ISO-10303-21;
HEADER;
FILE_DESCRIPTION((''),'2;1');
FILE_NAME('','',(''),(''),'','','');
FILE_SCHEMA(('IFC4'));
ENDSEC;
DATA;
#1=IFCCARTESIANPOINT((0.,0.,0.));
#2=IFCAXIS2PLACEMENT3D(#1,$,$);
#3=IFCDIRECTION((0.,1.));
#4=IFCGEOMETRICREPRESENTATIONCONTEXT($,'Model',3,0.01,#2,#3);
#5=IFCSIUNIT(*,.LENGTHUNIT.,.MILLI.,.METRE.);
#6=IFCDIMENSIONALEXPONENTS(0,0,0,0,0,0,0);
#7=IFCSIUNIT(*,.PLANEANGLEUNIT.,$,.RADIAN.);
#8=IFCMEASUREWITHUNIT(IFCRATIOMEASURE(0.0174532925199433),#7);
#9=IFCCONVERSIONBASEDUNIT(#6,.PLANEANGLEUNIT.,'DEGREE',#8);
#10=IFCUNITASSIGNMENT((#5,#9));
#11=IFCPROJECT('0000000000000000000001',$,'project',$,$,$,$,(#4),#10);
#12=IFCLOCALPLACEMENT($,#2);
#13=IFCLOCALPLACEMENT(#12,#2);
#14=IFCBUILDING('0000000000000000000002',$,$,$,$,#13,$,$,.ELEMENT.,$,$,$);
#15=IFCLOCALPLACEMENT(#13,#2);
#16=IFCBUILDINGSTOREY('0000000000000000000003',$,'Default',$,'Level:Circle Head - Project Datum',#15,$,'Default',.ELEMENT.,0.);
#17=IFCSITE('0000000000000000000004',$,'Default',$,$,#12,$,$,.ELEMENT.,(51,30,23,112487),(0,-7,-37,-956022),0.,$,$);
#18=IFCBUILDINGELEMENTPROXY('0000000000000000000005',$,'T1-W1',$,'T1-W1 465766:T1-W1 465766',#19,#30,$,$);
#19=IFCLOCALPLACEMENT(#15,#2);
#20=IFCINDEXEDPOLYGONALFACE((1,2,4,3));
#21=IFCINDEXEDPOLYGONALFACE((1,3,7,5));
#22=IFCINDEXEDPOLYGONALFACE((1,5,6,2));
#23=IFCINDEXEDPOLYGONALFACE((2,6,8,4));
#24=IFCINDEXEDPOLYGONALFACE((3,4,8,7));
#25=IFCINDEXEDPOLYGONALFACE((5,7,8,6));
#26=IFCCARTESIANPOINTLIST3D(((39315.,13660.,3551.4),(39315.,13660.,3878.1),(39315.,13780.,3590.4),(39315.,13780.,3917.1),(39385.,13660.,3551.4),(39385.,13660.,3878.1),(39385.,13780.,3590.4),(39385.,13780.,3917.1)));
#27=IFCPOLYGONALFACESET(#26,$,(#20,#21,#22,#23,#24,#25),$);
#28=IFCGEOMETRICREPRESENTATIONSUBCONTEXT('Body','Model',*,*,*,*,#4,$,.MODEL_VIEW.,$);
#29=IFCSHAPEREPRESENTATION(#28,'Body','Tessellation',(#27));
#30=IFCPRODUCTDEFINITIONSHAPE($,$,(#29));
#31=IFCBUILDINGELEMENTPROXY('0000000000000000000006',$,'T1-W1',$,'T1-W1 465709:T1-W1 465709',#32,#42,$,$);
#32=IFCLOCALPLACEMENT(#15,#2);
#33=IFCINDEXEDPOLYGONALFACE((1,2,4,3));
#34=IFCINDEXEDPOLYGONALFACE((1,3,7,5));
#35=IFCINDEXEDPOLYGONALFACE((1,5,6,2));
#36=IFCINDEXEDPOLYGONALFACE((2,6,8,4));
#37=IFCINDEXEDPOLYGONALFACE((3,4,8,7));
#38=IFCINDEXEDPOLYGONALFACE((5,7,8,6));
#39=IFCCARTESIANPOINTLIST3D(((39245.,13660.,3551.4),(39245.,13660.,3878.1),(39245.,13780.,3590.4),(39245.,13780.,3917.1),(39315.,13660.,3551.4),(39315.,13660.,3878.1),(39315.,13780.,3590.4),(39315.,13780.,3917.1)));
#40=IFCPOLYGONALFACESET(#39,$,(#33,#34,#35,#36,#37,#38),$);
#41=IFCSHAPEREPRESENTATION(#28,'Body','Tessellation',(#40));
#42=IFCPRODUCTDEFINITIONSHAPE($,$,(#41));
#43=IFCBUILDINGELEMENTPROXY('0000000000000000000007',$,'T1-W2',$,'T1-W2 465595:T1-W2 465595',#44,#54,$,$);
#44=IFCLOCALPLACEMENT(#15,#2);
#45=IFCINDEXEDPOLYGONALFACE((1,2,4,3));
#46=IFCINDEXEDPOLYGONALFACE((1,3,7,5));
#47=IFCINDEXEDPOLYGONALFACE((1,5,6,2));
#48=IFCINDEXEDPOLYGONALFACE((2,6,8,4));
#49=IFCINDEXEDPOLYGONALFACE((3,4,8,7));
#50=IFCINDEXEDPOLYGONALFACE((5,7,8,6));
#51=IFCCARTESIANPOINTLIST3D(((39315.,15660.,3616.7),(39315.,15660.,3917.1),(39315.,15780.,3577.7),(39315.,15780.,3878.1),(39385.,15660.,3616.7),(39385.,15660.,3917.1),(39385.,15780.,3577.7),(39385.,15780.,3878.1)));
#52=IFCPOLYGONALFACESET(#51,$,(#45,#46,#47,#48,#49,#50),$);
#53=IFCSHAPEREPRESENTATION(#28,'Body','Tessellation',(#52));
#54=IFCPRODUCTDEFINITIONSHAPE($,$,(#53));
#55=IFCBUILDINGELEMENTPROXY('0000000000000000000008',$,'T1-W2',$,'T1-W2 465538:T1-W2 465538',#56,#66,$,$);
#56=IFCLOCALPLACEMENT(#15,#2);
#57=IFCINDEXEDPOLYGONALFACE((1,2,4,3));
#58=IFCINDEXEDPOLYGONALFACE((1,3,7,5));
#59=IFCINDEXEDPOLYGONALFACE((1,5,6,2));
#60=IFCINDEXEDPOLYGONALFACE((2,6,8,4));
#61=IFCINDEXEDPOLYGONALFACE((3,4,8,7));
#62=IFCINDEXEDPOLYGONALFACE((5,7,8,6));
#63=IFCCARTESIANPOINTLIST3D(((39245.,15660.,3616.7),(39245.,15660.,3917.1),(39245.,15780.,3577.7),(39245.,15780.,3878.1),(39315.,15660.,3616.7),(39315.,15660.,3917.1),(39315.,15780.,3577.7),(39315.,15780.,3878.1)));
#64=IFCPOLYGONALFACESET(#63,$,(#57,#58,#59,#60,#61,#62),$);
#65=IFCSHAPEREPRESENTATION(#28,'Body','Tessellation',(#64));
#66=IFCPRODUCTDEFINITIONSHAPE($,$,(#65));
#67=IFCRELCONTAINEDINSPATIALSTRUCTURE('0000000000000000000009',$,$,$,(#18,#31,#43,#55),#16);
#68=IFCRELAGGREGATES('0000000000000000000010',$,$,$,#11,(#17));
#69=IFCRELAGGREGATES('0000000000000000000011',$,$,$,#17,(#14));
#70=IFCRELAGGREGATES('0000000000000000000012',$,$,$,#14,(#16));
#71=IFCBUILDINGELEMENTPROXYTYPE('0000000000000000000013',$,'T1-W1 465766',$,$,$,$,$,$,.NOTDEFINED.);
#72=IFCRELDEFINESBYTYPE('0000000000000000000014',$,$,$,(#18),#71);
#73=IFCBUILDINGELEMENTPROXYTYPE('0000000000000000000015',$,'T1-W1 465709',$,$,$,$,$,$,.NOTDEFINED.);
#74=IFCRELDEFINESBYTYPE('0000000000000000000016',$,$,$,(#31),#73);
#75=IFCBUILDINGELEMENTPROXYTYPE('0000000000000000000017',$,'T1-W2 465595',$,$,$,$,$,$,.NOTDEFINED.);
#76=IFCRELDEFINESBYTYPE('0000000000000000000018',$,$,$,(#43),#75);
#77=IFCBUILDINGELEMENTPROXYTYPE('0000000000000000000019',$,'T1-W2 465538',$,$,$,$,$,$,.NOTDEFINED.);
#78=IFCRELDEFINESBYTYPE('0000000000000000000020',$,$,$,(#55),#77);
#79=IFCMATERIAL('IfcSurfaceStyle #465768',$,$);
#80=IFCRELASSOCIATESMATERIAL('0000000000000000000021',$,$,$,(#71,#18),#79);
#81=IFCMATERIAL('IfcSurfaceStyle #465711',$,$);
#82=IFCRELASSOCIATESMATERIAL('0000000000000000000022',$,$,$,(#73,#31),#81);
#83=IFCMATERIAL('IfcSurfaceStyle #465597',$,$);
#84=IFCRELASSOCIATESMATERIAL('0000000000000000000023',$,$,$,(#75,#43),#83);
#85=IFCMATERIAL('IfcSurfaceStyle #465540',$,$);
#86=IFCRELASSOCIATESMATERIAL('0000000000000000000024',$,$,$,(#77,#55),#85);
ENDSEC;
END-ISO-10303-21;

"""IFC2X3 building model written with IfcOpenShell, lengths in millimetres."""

from ifc_helpers import new_model, entity, si_unit, converted_unit, direction, frame, origin, place, context, subcontext, project, spatial, polyline, outline, extrude, source, transform, mapped, material, type_object, type_shapes, element, save


model = new_model("IFC2X3")

# Units and contexts
model_context = context("Model", 3, precision=0.01, world=origin(), true_north=direction((0.0, 1.0)))
body_context = subcontext(model_context, "Body", "Model", "MODEL_VIEW")
ifc_project = project(units=[si_unit("LENGTHUNIT", "METRE", prefix="MILLI"), converted_unit("PLANEANGLEUNIT", "DEGREE", entity("IfcRatioMeasure", 0.0174532925199433), si_unit("PLANEANGLEUNIT", "RADIAN"), dimensions=[0, 0, 0, 0, 0, 0, 0])], contexts=[model_context])

# Site, building, storey
site_placement = place(None, origin())
site = spatial("IfcSite", under=ifc_project, at=site_placement, Name="Default", CompositionType="ELEMENT", RefLatitude=(51, 30, 23, 112487), RefLongitude=(0, -7, -37, -956022), RefElevation=0.0)
building_placement = place(site_placement, origin())
building = spatial("IfcBuilding", under=site, at=building_placement, CompositionType="ELEMENT")
storey_placement = place(building_placement, origin())
storey = spatial("IfcBuildingStorey", under=building, at=storey_placement, Name="Default", ObjectType="Level:Circle Head - Project Datum", LongName="Default", CompositionType="ELEMENT", Elevation=0.0)

# Building element proxies
ifc_material_1 = material(Name="IfcSurfaceStyle #465768")
building_element_proxy_type_1 = type_object("IfcBuildingElementProxyType", Name="T1-W1 465766", PredefinedType="NOTDEFINED", material=ifc_material_1)
shared_shape_1 = source(origin(), body_context, "Body", "SweptSolid", [
    extrude(outline(polyline([(-182.8, -60.0), (143.8, -60.0), (182.8, 60.0), (-143.8, 60.0), (-182.8, -60.0)])), frame((182.8, 60.0, 0.0), z_axis=(0.0, 0.0, 1.0), x_axis=(-1.0, 0.0, 0.0)), (0.0, 0.0, 1.0), 70.0),
])
type_shapes(building_element_proxy_type_1, [shared_shape_1])
proxy_1_placement = place(building_placement, frame((39385.0, 13660.0, 3551.4), z_axis=(-1.0, 0.0, 0.0), x_axis=(0.0, 0.0, 1.0)))
element("IfcBuildingElementProxy", 1, at=proxy_1_placement, inside=storey, type_object=building_element_proxy_type_1, material=ifc_material_1, Name="T1-W1", ObjectType="T1-W1 465766:T1-W1 465766", context=body_context, shape_type="MappedRepresentation", body=[
    mapped(shared_shape_1, transform((0.0, 0.0, 0.0), scale=1.0)),
])
ifc_material_2 = material(Name="IfcSurfaceStyle #465711")
building_element_proxy_type_2 = type_object("IfcBuildingElementProxyType", Name="T1-W1 465709", PredefinedType="NOTDEFINED", material=ifc_material_2)
shared_shape_2 = source(origin(), body_context, "Body", "SweptSolid", [
    extrude(outline(polyline([(-182.8, -60.0), (143.8, -60.0), (182.8, 60.0), (-143.8, 60.0), (-182.8, -60.0)])), frame((182.8, 60.0, 0.0), z_axis=(0.0, 0.0, 1.0), x_axis=(-1.0, 0.0, 0.0)), (0.0, 0.0, 1.0), 70.0),
])
type_shapes(building_element_proxy_type_2, [shared_shape_2])
proxy_2_placement = place(building_placement, frame((39315.0, 13660.0, 3551.4), z_axis=(-1.0, 0.0, 0.0), x_axis=(0.0, 0.0, 1.0)))
element("IfcBuildingElementProxy", 2, at=proxy_2_placement, inside=storey, type_object=building_element_proxy_type_2, material=ifc_material_2, Name="T1-W1", ObjectType="T1-W1 465709:T1-W1 465709", context=body_context, shape_type="MappedRepresentation", body=[
    mapped(shared_shape_2, transform((0.0, 0.0, 0.0), scale=1.0)),
])
ifc_material_3 = material(Name="IfcSurfaceStyle #465597")
building_element_proxy_type_3 = type_object("IfcBuildingElementProxyType", Name="T1-W2 465595", PredefinedType="NOTDEFINED", material=ifc_material_3)
shared_shape_3 = source(origin(), body_context, "Body", "SweptSolid", [
    extrude(outline(polyline([(-130.7, -60.0), (169.7, -60.0), (130.7, 60.0), (-169.7, 60.0), (-130.7, -60.0)])), frame((169.7, 60.0, 0.0), z_axis=(0.0, 0.0, 1.0), x_axis=(-1.0, 0.0, 0.0)), (0.0, 0.0, 1.0), 70.0),
])
type_shapes(building_element_proxy_type_3, [shared_shape_3])
proxy_3_placement = place(building_placement, frame((39385.0, 15660.0, 3577.7), z_axis=(-1.0, 0.0, 0.0), x_axis=(0.0, 0.0, 1.0)))
element("IfcBuildingElementProxy", 3, at=proxy_3_placement, inside=storey, type_object=building_element_proxy_type_3, material=ifc_material_3, Name="T1-W2", ObjectType="T1-W2 465595:T1-W2 465595", context=body_context, shape_type="MappedRepresentation", body=[
    mapped(shared_shape_3, transform((0.0, 0.0, 0.0), scale=1.0)),
])
ifc_material_4 = material(Name="IfcSurfaceStyle #465540")
building_element_proxy_type_4 = type_object("IfcBuildingElementProxyType", Name="T1-W2 465538", PredefinedType="NOTDEFINED", material=ifc_material_4)
shared_shape_4 = source(origin(), body_context, "Body", "SweptSolid", [
    extrude(outline(polyline([(-130.7, -60.0), (169.7, -60.0), (130.7, 60.0), (-169.7, 60.0), (-130.7, -60.0)])), frame((169.7, 60.0, 0.0), z_axis=(0.0, 0.0, 1.0), x_axis=(-1.0, 0.0, 0.0)), (0.0, 0.0, 1.0), 70.0),
])
type_shapes(building_element_proxy_type_4, [shared_shape_4])
proxy_4_placement = place(building_placement, frame((39315.0, 15660.0, 3577.7), z_axis=(-1.0, 0.0, 0.0), x_axis=(0.0, 0.0, 1.0)))
element("IfcBuildingElementProxy", 4, at=proxy_4_placement, inside=storey, type_object=building_element_proxy_type_4, material=ifc_material_4, Name="T1-W2", ObjectType="T1-W2 465538:T1-W2 465538", context=body_context, shape_type="MappedRepresentation", body=[
    mapped(shared_shape_4, transform((0.0, 0.0, 0.0), scale=1.0)),
])

save(model, "model.ifc")
